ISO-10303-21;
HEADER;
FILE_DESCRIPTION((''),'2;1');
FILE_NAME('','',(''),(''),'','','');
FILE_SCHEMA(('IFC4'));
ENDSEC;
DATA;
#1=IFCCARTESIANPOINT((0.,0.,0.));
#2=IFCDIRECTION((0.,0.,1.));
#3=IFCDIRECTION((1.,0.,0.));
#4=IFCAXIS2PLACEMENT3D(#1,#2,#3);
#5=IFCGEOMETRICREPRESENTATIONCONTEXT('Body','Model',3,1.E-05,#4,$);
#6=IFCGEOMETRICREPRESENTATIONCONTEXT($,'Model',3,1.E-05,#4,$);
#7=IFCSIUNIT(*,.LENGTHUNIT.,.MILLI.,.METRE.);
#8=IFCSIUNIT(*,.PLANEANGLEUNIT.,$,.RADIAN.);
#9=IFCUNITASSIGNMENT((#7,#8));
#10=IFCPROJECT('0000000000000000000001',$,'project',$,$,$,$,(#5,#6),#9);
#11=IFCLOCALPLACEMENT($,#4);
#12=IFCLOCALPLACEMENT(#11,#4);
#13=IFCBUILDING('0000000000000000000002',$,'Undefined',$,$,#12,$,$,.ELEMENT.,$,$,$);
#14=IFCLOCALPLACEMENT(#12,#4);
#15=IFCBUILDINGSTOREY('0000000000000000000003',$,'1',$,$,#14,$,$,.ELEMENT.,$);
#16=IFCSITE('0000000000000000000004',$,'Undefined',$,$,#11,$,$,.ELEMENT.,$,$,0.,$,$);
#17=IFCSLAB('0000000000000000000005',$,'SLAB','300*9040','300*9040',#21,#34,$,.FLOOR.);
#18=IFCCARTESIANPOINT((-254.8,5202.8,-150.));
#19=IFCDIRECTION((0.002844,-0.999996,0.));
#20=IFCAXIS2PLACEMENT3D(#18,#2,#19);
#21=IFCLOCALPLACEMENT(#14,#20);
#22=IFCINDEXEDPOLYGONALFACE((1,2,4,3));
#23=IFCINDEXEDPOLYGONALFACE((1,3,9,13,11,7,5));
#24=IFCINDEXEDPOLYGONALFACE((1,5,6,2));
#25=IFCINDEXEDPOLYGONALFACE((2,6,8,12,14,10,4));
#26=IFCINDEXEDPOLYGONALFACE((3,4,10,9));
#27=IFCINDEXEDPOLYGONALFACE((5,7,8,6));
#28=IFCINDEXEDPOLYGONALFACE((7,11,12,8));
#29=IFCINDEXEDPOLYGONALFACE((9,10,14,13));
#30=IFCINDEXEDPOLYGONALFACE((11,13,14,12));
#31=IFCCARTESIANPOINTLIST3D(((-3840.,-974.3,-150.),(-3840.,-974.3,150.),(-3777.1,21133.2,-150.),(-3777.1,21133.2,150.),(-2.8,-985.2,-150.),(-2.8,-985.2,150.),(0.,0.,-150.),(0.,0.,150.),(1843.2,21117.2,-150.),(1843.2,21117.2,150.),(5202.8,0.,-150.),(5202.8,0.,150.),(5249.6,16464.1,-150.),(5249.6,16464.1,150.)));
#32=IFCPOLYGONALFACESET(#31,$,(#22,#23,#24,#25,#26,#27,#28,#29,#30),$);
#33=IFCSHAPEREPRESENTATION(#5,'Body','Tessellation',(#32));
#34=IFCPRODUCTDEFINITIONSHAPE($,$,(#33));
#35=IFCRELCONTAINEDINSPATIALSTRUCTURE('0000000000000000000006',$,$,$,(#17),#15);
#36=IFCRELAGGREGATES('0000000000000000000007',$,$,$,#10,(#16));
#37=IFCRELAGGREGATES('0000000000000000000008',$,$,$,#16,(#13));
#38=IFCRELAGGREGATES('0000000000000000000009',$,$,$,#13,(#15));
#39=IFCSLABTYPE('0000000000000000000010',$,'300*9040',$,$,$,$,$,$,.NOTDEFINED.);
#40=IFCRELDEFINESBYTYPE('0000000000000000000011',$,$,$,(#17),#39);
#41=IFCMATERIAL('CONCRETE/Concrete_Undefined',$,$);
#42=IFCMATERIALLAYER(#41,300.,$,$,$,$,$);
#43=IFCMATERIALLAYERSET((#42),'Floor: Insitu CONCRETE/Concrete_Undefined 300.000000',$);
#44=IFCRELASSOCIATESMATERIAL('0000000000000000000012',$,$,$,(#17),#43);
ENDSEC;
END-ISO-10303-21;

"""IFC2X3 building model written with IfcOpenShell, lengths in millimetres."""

from ifc_helpers import new_model, si_unit, frame, origin_with_axes, place, context, project, spatial, polyline, outline, extrude, material, layer, layer_set, layer_usage, type_object, element, save


model = new_model("IFC2X3")

# Units and contexts
model_context_1 = context("Model", 3, precision=1e-05, world=origin_with_axes(), identifier="Body")
model_context_2 = context("Model", 3, precision=1e-05, world=origin_with_axes())
ifc_project = project(units=[si_unit("LENGTHUNIT", "METRE", prefix="MILLI"), si_unit("PLANEANGLEUNIT", "RADIAN")], contexts=[model_context_1, model_context_2])

# Site, building, storey
site_placement = place(None, origin_with_axes())
site = spatial("IfcSite", under=ifc_project, at=site_placement, Name="Undefined", CompositionType="ELEMENT", RefElevation=0.0)
building_placement = place(site_placement, origin_with_axes())
building = spatial("IfcBuilding", under=site, at=building_placement, Name="Undefined", CompositionType="ELEMENT")
storey_placement = place(building_placement, origin_with_axes())
storey = spatial("IfcBuildingStorey", under=building, at=storey_placement, Name="1", CompositionType="ELEMENT")

# Shared definitions
ifc_material = material(Name="CONCRETE/Concrete_Undefined")

# Slab
ifc_layer_1 = layer(ifc_material, 300.0)
ifc_layer_set_1 = layer_set([ifc_layer_1], Name="Floor: Insitu CONCRETE/Concrete_Undefined 300.000000")
ifc_layer_usage_1 = layer_usage(ifc_layer_set_1, "AXIS3", "POSITIVE", -150.0)
slab_type_1 = type_object("IfcSlabType", Name="300*9040", PredefinedType="NOTDEFINED")
slab_1_placement = place(storey_placement, frame((-254.8, 5202.8, -150.0), z_axis=(0.0, 0.0, 1.0), x_axis=(0.002844, -0.999996, 0.0)))
element("IfcSlab", 1, at=slab_1_placement, inside=storey, type_object=slab_type_1, material=ifc_layer_usage_1, Name="SLAB", Description="300*9040", ObjectType="300*9040", PredefinedType="FLOOR", context=model_context_1, shape_type="SweptSolid", body=[
    extrude(outline(polyline([(0.0, 0.0), (5202.8, 0.0), (5249.6, 16464.1), (1843.2, 21117.2), (-3777.1, 21133.2), (-3840.0, -974.3), (-2.8, -985.2), (0.0, 0.0)])), frame((0.0, 0.0, -150.0), z_axis=(0.0, 0.0, 1.0), x_axis=(1.0, 0.0, 0.0)), (0.0, 0.0, 1.0), 300.0),
])

save(model, "model.ifc")
